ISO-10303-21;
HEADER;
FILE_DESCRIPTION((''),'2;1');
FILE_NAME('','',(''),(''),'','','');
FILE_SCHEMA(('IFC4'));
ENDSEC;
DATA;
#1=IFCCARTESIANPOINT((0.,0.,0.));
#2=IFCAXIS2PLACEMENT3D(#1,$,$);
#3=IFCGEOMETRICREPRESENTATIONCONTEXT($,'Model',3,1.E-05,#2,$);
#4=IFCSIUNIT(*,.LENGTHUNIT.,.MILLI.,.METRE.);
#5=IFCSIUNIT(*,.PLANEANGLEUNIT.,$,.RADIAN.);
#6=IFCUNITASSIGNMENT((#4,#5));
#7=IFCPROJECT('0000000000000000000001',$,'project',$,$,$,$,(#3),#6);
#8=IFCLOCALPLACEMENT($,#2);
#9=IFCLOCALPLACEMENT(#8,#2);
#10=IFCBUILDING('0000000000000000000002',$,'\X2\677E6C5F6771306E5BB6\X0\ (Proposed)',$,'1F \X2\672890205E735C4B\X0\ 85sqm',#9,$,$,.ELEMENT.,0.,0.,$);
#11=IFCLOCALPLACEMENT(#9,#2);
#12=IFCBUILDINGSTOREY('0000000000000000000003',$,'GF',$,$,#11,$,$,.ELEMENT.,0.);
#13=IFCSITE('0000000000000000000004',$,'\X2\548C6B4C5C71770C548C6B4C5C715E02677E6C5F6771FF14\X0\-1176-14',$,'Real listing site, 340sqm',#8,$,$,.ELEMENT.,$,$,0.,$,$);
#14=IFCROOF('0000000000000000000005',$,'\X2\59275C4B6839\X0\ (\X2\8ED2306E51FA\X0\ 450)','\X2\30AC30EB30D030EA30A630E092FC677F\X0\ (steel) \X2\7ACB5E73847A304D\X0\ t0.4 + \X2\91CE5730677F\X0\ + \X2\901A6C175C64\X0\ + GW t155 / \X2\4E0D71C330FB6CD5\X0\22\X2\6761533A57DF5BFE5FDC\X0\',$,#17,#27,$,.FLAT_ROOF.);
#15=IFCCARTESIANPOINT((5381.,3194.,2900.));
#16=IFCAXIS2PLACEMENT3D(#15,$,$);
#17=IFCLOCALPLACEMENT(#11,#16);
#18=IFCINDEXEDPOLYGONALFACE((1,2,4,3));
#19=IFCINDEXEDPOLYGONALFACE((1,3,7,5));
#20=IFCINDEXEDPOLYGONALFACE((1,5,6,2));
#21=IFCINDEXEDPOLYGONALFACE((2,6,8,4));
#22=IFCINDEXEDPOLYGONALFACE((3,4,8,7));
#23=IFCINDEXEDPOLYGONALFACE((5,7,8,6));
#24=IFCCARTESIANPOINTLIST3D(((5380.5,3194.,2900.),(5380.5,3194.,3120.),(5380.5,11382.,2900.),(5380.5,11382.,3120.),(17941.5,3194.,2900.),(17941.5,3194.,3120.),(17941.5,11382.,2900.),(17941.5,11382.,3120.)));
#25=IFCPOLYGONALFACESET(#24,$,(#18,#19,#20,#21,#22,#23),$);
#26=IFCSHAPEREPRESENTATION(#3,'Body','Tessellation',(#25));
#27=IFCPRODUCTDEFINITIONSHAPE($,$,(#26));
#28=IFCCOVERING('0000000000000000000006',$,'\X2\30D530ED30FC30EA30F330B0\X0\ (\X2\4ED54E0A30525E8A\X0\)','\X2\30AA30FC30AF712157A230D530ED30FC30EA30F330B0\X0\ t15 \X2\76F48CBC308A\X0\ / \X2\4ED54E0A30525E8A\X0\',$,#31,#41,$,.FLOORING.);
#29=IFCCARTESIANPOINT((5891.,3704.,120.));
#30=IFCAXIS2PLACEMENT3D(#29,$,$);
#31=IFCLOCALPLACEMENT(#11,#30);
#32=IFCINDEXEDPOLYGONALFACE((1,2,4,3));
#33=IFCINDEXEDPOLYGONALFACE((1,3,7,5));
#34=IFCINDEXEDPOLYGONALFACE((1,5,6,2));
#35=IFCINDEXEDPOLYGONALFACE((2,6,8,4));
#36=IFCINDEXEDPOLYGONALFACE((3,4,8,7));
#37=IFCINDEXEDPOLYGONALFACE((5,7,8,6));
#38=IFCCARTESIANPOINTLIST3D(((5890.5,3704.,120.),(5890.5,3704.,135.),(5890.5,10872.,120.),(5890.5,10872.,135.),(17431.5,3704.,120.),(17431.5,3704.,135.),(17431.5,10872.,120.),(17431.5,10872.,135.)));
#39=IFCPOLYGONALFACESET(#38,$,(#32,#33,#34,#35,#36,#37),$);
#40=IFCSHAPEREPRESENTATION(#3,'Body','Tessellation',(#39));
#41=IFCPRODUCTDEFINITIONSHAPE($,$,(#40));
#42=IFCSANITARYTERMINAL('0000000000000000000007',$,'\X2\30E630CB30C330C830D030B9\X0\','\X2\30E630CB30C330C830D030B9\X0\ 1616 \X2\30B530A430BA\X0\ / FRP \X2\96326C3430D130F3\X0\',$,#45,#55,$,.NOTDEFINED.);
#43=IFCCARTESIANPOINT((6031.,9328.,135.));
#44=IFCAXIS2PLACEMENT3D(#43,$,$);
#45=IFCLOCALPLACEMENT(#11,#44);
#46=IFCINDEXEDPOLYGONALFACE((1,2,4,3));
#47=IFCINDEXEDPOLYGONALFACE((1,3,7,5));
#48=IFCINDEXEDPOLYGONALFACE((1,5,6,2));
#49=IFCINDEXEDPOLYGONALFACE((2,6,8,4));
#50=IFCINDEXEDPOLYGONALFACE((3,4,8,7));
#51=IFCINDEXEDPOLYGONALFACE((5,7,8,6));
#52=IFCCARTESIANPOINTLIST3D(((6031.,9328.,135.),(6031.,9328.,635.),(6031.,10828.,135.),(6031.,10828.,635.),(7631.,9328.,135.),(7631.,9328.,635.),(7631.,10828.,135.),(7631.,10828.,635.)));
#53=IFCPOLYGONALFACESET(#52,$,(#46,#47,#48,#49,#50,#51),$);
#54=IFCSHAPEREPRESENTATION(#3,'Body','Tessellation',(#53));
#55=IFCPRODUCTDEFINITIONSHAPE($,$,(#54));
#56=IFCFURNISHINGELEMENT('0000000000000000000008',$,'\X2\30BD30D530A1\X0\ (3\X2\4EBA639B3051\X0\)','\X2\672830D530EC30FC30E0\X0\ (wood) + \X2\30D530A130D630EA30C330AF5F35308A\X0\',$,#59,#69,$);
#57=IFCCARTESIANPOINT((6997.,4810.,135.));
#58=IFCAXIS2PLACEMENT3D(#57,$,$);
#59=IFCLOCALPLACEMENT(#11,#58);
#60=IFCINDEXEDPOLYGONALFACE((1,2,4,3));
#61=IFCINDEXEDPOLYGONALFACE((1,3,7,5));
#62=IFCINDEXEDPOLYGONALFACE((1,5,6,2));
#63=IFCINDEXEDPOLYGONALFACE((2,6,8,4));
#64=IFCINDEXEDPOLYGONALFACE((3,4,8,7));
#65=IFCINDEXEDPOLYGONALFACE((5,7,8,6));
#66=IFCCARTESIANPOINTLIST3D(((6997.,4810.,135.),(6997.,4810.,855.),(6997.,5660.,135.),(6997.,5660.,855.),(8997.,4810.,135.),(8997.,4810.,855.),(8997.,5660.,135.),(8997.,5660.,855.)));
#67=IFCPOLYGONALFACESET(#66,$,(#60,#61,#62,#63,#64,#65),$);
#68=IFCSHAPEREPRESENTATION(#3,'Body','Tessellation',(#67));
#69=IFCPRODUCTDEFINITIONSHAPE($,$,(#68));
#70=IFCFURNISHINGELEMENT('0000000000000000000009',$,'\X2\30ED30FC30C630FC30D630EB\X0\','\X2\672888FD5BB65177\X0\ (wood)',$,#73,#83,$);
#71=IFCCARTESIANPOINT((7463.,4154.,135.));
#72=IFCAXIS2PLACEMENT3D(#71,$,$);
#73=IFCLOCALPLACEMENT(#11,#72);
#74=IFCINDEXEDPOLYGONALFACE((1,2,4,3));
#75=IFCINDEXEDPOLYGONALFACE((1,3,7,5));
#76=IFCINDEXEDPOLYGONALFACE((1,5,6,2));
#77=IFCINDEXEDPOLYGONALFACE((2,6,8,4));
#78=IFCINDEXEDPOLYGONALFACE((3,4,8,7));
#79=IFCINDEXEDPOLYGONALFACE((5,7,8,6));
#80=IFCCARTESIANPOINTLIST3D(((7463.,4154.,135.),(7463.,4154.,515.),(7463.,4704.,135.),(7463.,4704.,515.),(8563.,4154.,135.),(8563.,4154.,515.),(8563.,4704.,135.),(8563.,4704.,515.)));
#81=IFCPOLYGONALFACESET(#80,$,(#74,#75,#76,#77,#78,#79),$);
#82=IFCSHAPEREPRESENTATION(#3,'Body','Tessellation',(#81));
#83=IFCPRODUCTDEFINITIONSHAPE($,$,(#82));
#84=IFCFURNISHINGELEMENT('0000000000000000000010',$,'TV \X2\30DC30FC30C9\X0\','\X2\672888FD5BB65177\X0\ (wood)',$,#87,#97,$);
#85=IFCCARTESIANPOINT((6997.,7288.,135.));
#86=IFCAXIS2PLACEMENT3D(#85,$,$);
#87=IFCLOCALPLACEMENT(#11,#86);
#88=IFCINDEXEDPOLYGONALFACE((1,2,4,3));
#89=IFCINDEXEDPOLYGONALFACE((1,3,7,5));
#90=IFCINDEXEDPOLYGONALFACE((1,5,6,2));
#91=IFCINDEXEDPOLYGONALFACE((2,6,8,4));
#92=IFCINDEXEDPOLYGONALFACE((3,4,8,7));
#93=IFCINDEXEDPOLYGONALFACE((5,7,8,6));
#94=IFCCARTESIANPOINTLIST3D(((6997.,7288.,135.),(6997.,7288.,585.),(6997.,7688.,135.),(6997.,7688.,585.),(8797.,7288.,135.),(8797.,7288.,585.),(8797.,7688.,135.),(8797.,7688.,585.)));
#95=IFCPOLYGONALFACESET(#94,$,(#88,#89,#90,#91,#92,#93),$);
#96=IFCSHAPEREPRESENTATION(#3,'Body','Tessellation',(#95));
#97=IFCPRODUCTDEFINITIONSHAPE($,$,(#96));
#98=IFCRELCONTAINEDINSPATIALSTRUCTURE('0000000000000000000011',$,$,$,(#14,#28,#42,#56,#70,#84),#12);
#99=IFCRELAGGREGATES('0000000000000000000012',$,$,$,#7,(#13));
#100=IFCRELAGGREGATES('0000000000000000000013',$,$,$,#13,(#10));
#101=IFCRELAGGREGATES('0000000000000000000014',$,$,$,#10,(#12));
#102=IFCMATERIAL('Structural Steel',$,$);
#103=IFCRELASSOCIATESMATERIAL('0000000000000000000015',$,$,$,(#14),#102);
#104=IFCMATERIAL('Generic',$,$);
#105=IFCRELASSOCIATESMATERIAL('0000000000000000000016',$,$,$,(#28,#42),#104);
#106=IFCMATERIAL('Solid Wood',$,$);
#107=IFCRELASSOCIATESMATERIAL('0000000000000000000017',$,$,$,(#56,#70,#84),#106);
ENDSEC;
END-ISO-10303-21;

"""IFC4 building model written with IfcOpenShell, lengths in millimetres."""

from ifc_helpers import new_model, si_unit, frame, frame_2d, origin, place, context, project, spatial, rectangle, extrude, material, element, save


model = new_model("IFC4")

# Units and contexts
model_context = context("Model", 3, precision=1e-05, world=origin())
ifc_project = project(units=[si_unit("LENGTHUNIT", "METRE", prefix="MILLI"), si_unit("PLANEANGLEUNIT", "RADIAN")], contexts=[model_context])

# Site, building, storey
site_placement = place(None, origin())
site = spatial("IfcSite", under=ifc_project, at=site_placement, Name="和歌山県和歌山市松江東４-1176-14", ObjectType="Real listing site, 340sqm", CompositionType="ELEMENT", RefElevation=0.0)
building_placement = place(site_placement, origin())
building = spatial("IfcBuilding", under=site, at=building_placement, Name="松江東の家 (Proposed)", ObjectType="1F 木造平屋 85sqm", CompositionType="ELEMENT", ElevationOfRefHeight=0.0, ElevationOfTerrain=0.0)
storey_placement = place(building_placement, origin())
storey = spatial("IfcBuildingStorey", under=building, at=storey_placement, Name="GF", CompositionType="ELEMENT", Elevation=0.0)

# Shared definitions
ifc_material_1 = material(Name="Solid Wood")

# Roof
ifc_material_2 = material(Name="Structural Steel")
roof_placement = place(storey_placement, frame((5381.0, 3194.0, 2900.0)))
element("IfcRoof", 1, at=roof_placement, inside=storey, material=ifc_material_2, Name="大屋根 (軒の出 450)", Description="ガルバリウム鋼板 (steel) 立平葺き t0.4 + 野地板 + 通気層 + GW t155 / 不燃・法22条区域対応", PredefinedType="FLAT_ROOF", context=model_context, shape_type="SweptSolid", body=[
    extrude(rectangle(XDim=12561.0, YDim=8188.0, at=frame_2d((6280.0, 4094.0))), frame((5381.0, 3194.0, 2900.0)), (0.0, 0.0, 1.0), 220.0),
])

# Covering
ifc_material_3 = material(Name="Generic")
covering_placement = place(storey_placement, frame((5891.0, 3704.0, 120.0)))
element("IfcCovering", 2, at=covering_placement, inside=storey, material=ifc_material_3, Name="フローリング (仕上げ床)", Description="オーク無垢フローリング t15 直貼り / 仕上げ床", PredefinedType="FLOORING", context=model_context, shape_type="SweptSolid", body=[
    extrude(rectangle(XDim=11541.0, YDim=7168.0, at=frame_2d((5770.0, 3584.0))), frame((5891.0, 3704.0, 120.0)), (0.0, 0.0, 1.0), 15.0),
])

# Sanitary terminal
sanitary_terminal_placement = place(storey_placement, frame((6031.0, 9328.0, 135.0)))
element("IfcSanitaryTerminal", 3, at=sanitary_terminal_placement, inside=storey, material=ifc_material_3, Name="ユニットバス", Description="ユニットバス 1616 サイズ / FRP 防水パン", PredefinedType="NOTDEFINED", context=model_context, shape_type="SweptSolid", body=[
    extrude(rectangle(XDim=1600.0, YDim=1500.0, at=frame_2d((800.0, 750.0))), frame((6031.0, 9328.0, 135.0)), (0.0, 0.0, 1.0), 500.0),
])

# Furnishing elements
furnishing_1_placement = place(storey_placement, frame((6997.0, 4810.0, 135.0)))
element("IfcFurnishingElement", 4, at=furnishing_1_placement, inside=storey, material=ifc_material_1, Name="ソファ (3人掛け)", Description="木フレーム (wood) + ファブリック張り", context=model_context, shape_type="SweptSolid", body=[
    extrude(rectangle(XDim=2000.0, YDim=850.0, at=frame_2d((1000.0, 425.0))), frame((6997.0, 4810.0, 135.0)), (0.0, 0.0, 1.0), 720.0),
])
furnishing_2_placement = place(storey_placement, frame((7463.0, 4154.0, 135.0)))
element("IfcFurnishingElement", 5, at=furnishing_2_placement, inside=storey, material=ifc_material_1, Name="ローテーブル", Description="木製家具 (wood)", context=model_context, shape_type="SweptSolid", body=[
    extrude(rectangle(XDim=1100.0, YDim=550.0, at=frame_2d((550.0, 275.0))), frame((7463.0, 4154.0, 135.0)), (0.0, 0.0, 1.0), 380.0),
])
furnishing_3_placement = place(storey_placement, frame((6997.0, 7288.0, 135.0)))
element("IfcFurnishingElement", 6, at=furnishing_3_placement, inside=storey, material=ifc_material_1, Name="TV ボード", Description="木製家具 (wood)", context=model_context, shape_type="SweptSolid", body=[
    extrude(rectangle(XDim=1800.0, YDim=400.0, at=frame_2d((900.0, 200.0))), frame((6997.0, 7288.0, 135.0)), (0.0, 0.0, 1.0), 450.0),
])

save(model, "model.ifc")
